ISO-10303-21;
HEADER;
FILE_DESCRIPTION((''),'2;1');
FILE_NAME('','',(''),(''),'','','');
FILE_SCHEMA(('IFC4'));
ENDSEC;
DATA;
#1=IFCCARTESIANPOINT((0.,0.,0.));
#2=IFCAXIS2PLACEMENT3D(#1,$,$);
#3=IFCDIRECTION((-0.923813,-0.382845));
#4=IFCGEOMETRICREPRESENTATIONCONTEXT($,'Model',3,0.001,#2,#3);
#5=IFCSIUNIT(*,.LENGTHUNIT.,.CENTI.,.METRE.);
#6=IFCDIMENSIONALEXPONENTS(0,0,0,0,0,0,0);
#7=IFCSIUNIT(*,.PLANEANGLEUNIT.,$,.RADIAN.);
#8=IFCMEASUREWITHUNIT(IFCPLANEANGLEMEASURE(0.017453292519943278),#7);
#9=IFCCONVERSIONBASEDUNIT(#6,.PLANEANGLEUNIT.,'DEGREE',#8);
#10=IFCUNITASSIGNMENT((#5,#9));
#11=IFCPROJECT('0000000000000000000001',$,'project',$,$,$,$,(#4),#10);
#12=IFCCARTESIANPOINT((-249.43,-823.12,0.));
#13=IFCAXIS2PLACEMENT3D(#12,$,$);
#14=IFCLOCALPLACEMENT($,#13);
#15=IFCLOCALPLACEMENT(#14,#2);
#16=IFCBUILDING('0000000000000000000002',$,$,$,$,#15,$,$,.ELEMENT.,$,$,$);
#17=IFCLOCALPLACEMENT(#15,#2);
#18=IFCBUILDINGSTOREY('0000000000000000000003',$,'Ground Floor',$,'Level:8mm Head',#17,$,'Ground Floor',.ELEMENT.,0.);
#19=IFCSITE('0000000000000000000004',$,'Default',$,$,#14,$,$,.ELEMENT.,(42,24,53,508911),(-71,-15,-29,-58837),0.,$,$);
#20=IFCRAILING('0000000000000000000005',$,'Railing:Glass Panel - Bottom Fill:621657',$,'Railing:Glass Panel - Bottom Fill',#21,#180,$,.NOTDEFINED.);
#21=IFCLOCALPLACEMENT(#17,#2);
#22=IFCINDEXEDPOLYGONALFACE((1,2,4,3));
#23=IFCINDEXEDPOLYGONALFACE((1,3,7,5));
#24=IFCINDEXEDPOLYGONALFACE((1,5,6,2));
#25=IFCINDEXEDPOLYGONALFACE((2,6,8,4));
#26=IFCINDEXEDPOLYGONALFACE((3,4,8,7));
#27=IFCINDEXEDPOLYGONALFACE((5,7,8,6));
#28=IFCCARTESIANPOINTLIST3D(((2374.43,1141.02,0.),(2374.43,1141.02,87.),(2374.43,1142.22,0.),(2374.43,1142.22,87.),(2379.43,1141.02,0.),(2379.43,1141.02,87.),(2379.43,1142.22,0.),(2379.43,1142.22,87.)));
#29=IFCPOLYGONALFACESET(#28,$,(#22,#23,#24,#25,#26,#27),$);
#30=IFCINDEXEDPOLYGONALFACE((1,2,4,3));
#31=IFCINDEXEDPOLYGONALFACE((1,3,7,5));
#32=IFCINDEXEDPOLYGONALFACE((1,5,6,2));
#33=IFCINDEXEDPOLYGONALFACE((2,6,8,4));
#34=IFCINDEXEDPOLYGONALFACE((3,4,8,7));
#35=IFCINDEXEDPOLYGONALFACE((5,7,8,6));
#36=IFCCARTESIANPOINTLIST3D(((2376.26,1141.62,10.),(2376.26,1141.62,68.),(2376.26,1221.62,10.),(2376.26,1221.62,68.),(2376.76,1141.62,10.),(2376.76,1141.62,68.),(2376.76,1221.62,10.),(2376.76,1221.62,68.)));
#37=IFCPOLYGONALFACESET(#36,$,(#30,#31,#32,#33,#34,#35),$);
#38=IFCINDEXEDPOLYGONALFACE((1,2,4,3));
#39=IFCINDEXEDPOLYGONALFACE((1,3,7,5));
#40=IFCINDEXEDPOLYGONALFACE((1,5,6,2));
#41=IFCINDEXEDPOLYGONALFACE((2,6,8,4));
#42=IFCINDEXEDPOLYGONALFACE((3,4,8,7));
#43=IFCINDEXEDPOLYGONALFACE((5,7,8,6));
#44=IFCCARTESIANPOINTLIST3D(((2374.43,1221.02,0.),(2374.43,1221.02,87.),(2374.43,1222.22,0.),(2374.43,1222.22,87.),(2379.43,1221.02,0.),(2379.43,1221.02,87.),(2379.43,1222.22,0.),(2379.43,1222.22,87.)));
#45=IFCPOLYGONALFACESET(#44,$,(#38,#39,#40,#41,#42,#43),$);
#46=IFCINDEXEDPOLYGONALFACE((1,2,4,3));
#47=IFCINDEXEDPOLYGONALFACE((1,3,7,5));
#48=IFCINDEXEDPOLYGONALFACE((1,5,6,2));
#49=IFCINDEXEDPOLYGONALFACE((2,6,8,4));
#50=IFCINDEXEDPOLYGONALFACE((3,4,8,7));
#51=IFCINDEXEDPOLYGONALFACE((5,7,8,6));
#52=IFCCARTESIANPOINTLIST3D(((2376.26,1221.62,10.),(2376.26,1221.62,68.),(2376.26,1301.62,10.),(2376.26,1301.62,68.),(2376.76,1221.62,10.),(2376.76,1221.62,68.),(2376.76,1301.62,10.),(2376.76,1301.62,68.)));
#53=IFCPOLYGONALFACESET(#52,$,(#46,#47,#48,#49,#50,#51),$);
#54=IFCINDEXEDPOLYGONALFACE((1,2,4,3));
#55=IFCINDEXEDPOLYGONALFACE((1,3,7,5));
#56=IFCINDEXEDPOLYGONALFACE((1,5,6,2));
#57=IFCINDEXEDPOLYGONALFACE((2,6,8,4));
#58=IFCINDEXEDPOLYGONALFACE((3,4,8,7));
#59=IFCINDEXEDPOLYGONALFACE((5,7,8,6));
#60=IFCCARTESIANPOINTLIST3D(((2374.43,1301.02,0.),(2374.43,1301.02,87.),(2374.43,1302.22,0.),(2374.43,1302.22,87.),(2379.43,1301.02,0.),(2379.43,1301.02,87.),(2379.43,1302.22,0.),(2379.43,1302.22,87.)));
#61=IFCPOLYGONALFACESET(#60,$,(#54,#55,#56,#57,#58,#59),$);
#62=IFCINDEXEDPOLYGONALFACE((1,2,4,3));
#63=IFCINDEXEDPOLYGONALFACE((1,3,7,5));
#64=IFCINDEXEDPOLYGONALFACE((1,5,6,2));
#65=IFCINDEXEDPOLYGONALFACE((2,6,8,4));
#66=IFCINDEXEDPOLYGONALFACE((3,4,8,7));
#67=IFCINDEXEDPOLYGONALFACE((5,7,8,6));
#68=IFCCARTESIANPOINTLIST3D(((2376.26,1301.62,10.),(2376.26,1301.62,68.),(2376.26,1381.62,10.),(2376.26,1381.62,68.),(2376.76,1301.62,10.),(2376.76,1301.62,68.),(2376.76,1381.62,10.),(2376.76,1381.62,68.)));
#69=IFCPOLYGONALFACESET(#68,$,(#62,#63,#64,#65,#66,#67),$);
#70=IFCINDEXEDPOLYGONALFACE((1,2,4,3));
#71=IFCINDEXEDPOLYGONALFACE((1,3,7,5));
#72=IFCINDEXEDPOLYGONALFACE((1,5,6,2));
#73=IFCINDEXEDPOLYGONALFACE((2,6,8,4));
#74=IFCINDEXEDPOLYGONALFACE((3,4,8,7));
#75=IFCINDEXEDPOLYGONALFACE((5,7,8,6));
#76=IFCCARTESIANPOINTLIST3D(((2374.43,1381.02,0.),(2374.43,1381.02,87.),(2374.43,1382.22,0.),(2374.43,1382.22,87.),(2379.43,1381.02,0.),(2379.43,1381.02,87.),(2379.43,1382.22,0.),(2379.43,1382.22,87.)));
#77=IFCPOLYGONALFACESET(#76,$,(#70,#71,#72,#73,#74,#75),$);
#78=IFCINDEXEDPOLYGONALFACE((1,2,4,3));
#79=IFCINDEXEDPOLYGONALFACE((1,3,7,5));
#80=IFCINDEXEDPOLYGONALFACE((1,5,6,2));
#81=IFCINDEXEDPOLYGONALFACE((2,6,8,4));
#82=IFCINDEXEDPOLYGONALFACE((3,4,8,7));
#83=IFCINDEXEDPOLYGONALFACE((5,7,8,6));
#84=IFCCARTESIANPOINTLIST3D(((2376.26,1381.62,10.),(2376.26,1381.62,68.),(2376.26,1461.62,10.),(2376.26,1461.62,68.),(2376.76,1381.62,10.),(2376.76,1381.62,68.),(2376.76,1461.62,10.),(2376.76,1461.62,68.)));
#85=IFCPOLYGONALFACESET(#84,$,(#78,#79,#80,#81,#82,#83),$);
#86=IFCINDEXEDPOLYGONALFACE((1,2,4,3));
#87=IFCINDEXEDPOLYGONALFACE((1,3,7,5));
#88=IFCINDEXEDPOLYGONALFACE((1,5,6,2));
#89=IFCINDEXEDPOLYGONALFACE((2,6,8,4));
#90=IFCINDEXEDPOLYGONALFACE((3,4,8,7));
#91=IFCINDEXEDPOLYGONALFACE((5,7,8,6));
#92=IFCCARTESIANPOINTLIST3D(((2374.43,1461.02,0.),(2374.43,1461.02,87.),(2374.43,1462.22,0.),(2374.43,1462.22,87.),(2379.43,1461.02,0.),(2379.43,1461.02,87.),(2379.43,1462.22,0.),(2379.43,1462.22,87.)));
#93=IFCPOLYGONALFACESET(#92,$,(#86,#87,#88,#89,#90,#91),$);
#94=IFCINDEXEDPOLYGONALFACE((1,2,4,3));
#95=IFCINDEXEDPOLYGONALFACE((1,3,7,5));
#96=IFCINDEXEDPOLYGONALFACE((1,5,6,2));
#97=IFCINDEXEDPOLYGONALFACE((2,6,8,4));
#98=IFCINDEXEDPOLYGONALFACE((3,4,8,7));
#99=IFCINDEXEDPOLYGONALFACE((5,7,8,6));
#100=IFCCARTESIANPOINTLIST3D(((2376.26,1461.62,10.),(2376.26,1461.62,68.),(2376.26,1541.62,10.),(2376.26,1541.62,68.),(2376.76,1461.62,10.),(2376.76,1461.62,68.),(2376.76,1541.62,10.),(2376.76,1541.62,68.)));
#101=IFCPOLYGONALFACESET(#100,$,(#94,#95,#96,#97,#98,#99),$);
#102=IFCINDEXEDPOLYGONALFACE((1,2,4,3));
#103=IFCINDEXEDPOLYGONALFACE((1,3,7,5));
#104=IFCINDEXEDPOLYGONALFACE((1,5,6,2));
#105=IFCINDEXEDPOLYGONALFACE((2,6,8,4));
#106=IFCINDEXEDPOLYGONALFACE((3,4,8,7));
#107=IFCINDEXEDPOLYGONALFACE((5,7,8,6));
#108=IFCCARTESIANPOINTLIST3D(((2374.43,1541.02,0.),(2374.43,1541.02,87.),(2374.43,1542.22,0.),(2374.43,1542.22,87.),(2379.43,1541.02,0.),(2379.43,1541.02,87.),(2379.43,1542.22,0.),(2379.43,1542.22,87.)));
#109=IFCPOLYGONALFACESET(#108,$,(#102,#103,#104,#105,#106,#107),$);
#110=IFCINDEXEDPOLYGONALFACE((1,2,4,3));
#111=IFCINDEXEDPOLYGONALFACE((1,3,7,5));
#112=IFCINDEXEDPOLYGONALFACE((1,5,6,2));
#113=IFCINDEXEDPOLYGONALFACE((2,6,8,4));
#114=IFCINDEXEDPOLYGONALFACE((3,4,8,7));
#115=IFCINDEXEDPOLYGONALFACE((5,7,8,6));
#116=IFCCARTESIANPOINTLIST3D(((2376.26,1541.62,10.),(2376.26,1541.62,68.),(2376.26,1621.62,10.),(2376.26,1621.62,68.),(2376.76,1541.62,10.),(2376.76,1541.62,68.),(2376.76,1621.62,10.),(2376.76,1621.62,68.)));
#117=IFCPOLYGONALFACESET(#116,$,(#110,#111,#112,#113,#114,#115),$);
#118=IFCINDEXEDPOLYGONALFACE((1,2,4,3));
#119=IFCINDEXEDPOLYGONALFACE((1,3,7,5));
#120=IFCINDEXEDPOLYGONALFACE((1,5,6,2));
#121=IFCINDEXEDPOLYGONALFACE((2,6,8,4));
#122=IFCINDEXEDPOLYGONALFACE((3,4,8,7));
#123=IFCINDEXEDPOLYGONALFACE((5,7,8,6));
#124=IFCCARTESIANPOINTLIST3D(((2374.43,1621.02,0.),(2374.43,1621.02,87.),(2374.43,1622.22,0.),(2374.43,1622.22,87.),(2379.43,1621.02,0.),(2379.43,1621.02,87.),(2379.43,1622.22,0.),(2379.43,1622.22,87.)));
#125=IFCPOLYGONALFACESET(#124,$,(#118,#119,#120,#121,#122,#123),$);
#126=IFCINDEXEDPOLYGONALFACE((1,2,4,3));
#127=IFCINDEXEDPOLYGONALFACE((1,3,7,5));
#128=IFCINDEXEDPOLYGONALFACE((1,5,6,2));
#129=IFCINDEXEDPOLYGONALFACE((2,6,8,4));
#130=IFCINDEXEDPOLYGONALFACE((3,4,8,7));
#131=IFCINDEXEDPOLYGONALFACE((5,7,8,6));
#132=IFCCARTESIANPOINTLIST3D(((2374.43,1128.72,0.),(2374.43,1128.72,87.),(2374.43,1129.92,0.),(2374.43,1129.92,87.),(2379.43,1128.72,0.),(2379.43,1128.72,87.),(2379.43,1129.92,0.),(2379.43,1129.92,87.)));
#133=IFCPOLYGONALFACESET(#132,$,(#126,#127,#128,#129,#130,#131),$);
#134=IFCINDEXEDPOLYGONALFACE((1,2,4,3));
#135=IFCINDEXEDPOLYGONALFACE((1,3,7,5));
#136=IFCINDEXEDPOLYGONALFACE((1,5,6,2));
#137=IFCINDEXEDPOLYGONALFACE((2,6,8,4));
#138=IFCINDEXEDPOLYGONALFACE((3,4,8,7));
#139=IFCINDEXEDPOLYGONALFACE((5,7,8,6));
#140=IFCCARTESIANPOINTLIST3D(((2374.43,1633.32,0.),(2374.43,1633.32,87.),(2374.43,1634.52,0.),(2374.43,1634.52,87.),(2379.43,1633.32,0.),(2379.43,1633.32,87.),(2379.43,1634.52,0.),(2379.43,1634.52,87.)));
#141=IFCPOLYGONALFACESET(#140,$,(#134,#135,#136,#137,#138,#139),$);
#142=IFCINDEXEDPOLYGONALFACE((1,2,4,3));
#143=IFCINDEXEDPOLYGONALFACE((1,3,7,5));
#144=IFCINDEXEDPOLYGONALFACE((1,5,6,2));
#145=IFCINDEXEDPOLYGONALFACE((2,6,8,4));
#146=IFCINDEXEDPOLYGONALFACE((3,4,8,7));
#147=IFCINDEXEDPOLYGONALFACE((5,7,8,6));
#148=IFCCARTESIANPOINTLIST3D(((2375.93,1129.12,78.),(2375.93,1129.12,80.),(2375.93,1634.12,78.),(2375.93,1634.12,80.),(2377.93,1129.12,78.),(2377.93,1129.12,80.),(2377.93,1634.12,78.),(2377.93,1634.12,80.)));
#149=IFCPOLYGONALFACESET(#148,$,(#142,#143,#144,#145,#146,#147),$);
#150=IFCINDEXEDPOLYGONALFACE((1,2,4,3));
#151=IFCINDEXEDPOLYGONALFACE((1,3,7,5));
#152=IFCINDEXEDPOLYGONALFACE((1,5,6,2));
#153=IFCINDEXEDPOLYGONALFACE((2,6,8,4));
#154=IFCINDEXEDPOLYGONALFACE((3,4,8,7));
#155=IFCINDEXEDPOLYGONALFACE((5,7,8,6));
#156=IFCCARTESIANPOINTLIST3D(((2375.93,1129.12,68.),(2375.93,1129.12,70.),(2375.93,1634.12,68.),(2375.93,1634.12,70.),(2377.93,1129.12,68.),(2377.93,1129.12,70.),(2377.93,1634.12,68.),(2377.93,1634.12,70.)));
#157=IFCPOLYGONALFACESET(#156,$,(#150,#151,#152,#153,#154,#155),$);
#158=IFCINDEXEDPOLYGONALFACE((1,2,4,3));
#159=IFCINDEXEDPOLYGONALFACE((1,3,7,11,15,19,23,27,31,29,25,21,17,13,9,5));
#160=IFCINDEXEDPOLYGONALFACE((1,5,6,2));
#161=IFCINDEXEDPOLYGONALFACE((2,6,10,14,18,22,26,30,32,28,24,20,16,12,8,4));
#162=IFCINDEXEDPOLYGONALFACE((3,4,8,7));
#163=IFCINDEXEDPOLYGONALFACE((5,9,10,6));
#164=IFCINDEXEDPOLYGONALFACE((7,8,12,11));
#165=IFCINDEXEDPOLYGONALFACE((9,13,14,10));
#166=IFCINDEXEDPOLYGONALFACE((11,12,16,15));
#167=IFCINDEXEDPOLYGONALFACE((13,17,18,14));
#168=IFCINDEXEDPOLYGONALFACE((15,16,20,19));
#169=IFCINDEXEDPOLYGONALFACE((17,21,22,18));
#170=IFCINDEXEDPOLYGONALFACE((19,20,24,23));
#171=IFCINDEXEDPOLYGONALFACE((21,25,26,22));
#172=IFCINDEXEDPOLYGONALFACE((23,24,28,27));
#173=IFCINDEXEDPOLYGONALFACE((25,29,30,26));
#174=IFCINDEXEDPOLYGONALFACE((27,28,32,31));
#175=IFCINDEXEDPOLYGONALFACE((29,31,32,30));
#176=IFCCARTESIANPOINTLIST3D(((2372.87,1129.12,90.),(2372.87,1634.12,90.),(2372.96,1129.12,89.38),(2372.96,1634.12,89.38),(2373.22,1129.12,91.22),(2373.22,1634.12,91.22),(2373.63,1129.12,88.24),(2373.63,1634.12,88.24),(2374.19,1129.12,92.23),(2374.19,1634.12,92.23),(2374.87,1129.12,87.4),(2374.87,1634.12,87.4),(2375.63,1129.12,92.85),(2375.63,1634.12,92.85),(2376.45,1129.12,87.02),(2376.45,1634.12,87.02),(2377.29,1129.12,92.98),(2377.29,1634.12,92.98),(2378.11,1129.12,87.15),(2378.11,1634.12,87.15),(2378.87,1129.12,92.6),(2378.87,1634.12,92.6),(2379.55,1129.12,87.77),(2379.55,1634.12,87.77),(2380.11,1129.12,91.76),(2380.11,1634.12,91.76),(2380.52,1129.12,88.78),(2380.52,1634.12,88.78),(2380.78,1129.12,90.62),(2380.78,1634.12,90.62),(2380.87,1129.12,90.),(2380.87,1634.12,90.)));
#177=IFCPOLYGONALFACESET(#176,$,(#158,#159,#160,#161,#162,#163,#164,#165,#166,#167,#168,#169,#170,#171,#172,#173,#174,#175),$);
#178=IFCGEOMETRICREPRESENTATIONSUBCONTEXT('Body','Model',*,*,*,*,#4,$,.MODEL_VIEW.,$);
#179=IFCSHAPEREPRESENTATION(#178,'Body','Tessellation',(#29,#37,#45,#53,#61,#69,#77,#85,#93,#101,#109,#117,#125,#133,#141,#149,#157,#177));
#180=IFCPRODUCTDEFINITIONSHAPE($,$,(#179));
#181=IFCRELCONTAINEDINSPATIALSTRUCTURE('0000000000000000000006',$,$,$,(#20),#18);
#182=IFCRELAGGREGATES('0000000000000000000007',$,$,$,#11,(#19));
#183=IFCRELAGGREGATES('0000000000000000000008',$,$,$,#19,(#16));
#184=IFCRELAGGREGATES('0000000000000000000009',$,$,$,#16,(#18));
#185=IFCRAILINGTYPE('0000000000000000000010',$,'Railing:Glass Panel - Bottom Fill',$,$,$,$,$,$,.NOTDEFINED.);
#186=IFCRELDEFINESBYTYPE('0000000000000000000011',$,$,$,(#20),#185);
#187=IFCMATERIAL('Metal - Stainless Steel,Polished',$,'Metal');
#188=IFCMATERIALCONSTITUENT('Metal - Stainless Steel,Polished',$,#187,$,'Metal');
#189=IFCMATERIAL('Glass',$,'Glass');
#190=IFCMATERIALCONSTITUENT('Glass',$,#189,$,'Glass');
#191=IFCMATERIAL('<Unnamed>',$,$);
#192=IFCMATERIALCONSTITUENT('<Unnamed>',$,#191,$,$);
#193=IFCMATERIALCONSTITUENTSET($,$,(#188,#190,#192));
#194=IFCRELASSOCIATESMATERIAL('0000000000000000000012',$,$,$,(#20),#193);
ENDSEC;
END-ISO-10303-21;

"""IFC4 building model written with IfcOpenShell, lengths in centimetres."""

from ifc_helpers import new_model, entity, si_unit, converted_unit, direction, frame, origin, place, context, subcontext, project, spatial, indexed_curve, outline, extrude, material, constituent, constituent_set, type_object, element, save


model = new_model("IFC4")

# Units and contexts
model_context = context("Model", 3, precision=0.001, world=origin(), true_north=direction((-0.923813, -0.382845)))
body_context = subcontext(model_context, "Body", "Model", "MODEL_VIEW")
ifc_project = project(units=[si_unit("LENGTHUNIT", "METRE", prefix="CENTI"), converted_unit("PLANEANGLEUNIT", "DEGREE", entity("IfcPlaneAngleMeasure", 0.017453292519943278), si_unit("PLANEANGLEUNIT", "RADIAN"), dimensions=[0, 0, 0, 0, 0, 0, 0])], contexts=[model_context])

# Site, building, storey
site_placement = place(None, frame((-249.43, -823.12, 0.0)))
site = spatial("IfcSite", under=ifc_project, at=site_placement, Name="Default", CompositionType="ELEMENT", RefLatitude=(42, 24, 53, 508911), RefLongitude=(-71, -15, -29, -58837), RefElevation=0.0)
building_placement = place(site_placement, origin())
building = spatial("IfcBuilding", under=site, at=building_placement, CompositionType="ELEMENT")
storey_placement = place(building_placement, origin())
storey = spatial("IfcBuildingStorey", under=building, at=storey_placement, Name="Ground Floor", ObjectType="Level:8mm Head", LongName="Ground Floor", CompositionType="ELEMENT", Elevation=0.0)

# Shared definitions
ifc_material_1 = material(Name="Glass", Category="Glass")

# Railing
ifc_material_2 = material(Name="Metal - Stainless Steel,Polished", Category="Metal")
ifc_constituent_1 = constituent(ifc_material_2, Name="Metal - Stainless Steel,Polished", Category="Metal")
ifc_constituent_2 = constituent(ifc_material_1, Name="Glass", Category="Glass")
ifc_material_3 = material(Name="<Unnamed>")
ifc_constituent_3 = constituent(ifc_material_3, Name="<Unnamed>")
ifc_constituent_set_1 = constituent_set(constituents=[ifc_constituent_1, ifc_constituent_2, ifc_constituent_3])
railing_type = type_object("IfcRailingType", Name="Railing:Glass Panel - Bottom Fill", PredefinedType="NOTDEFINED")
railing_1_placement = place(storey_placement, frame((2372.71, 1128.72, 0.0)))
element("IfcRailing", 1, at=railing_1_placement, inside=storey, type_object=railing_type, material=ifc_constituent_set_1, Name="Railing:Glass Panel - Bottom Fill:621657", ObjectType="Railing:Glass Panel - Bottom Fill", PredefinedType="NOTDEFINED", context=body_context, shape_type="SweptSolid", body=[
    extrude(outline(indexed_curve([(-2.5, -0.6), (2.5, -0.6), (2.5, 0.6), (-2.5, 0.6), (-2.5, -0.6)], self_intersect=False)), frame((4.22, 12.9, 0.0), z_axis=(0.0, 0.0, 1.0), x_axis=(-1.0, 0.0, 0.0)), (0.0, 0.0, 1.0), 87.0),
    extrude(outline(indexed_curve([(-0.25, -40.0), (0.25, -40.0), (0.25, 40.0), (-0.25, 40.0), (-0.25, -40.0)], self_intersect=False)), frame((3.8, 52.9, 10.0), z_axis=(0.0, 0.0, 1.0), x_axis=(-1.0, 0.0, 0.0)), (0.0, 0.0, 1.0), 58.0),
    extrude(outline(indexed_curve([(-2.5, -0.6), (2.5, -0.6), (2.5, 0.6), (-2.5, 0.6), (-2.5, -0.6)], self_intersect=False)), frame((4.22, 92.9, 0.0), z_axis=(0.0, 0.0, 1.0), x_axis=(-1.0, 0.0, 0.0)), (0.0, 0.0, 1.0), 87.0),
    extrude(outline(indexed_curve([(-0.25, -40.0), (0.25, -40.0), (0.25, 40.0), (-0.25, 40.0), (-0.25, -40.0)], self_intersect=False)), frame((3.8, 132.9, 10.0), z_axis=(0.0, 0.0, 1.0), x_axis=(-1.0, 0.0, 0.0)), (0.0, 0.0, 1.0), 58.0),
    extrude(outline(indexed_curve([(-2.5, -0.6), (2.5, -0.6), (2.5, 0.6), (-2.5, 0.6), (-2.5, -0.6)], self_intersect=False)), frame((4.22, 172.9, 0.0), z_axis=(0.0, 0.0, 1.0), x_axis=(-1.0, 0.0, 0.0)), (0.0, 0.0, 1.0), 87.0),
    extrude(outline(indexed_curve([(-0.25, -40.0), (0.25, -40.0), (0.25, 40.0), (-0.25, 40.0), (-0.25, -40.0)], self_intersect=False)), frame((3.8, 212.9, 10.0), z_axis=(0.0, 0.0, 1.0), x_axis=(-1.0, 0.0, 0.0)), (0.0, 0.0, 1.0), 58.0),
    extrude(outline(indexed_curve([(-2.5, -0.6), (2.5, -0.6), (2.5, 0.6), (-2.5, 0.6), (-2.5, -0.6)], self_intersect=False)), frame((4.22, 252.9, 0.0), z_axis=(0.0, 0.0, 1.0), x_axis=(-1.0, 0.0, 0.0)), (0.0, 0.0, 1.0), 87.0),
    extrude(outline(indexed_curve([(-0.25, -40.0), (0.25, -40.0), (0.25, 40.0), (-0.25, 40.0), (-0.25, -40.0)], self_intersect=False)), frame((3.8, 292.9, 10.0), z_axis=(0.0, 0.0, 1.0), x_axis=(-1.0, 0.0, 0.0)), (0.0, 0.0, 1.0), 58.0),
    extrude(outline(indexed_curve([(-2.5, -0.6), (2.5, -0.6), (2.5, 0.6), (-2.5, 0.6), (-2.5, -0.6)], self_intersect=False)), frame((4.22, 332.9, 0.0), z_axis=(0.0, 0.0, 1.0), x_axis=(-1.0, 0.0, 0.0)), (0.0, 0.0, 1.0), 87.0),
    extrude(outline(indexed_curve([(-0.25, -40.0), (0.25, -40.0), (0.25, 40.0), (-0.25, 40.0), (-0.25, -40.0)], self_intersect=False)), frame((3.8, 372.9, 10.0), z_axis=(0.0, 0.0, 1.0), x_axis=(-1.0, 0.0, 0.0)), (0.0, 0.0, 1.0), 58.0),
    extrude(outline(indexed_curve([(-2.5, -0.6), (2.5, -0.6), (2.5, 0.6), (-2.5, 0.6), (-2.5, -0.6)], self_intersect=False)), frame((4.22, 412.9, 0.0), z_axis=(0.0, 0.0, 1.0), x_axis=(-1.0, 0.0, 0.0)), (0.0, 0.0, 1.0), 87.0),
    extrude(outline(indexed_curve([(-0.25, -40.0), (0.25, -40.0), (0.25, 40.0), (-0.25, 40.0), (-0.25, -40.0)], self_intersect=False)), frame((3.8, 452.9, 10.0), z_axis=(0.0, 0.0, 1.0), x_axis=(-1.0, 0.0, 0.0)), (0.0, 0.0, 1.0), 58.0),
    extrude(outline(indexed_curve([(-2.5, -0.6), (2.5, -0.6), (2.5, 0.6), (-2.5, 0.6), (-2.5, -0.6)], self_intersect=False)), frame((4.22, 492.9, 0.0), z_axis=(0.0, 0.0, 1.0), x_axis=(-1.0, 0.0, 0.0)), (0.0, 0.0, 1.0), 87.0),
    extrude(outline(indexed_curve([(-2.5, -0.6), (2.5, -0.6), (2.5, 0.6), (-2.5, 0.6), (-2.5, -0.6)], self_intersect=False)), frame((4.22, 0.6, 0.0), z_axis=(0.0, 0.0, 1.0), x_axis=(-1.0, 0.0, 0.0)), (0.0, 0.0, 1.0), 87.0),
    extrude(outline(indexed_curve([(-2.5, -0.6), (2.5, -0.6), (2.5, 0.6), (-2.5, 0.6), (-2.5, -0.6)], self_intersect=False)), frame((4.22, 505.2, 0.0), z_axis=(0.0, 0.0, 1.0), x_axis=(-1.0, 0.0, 0.0)), (0.0, 0.0, 1.0), 87.0),
    extrude(outline(indexed_curve([(-252.5, -1.0), (252.5, -1.0), (252.5, 1.0), (-252.5, 1.0), (-252.5, -1.0)], self_intersect=False)), frame((4.22, 252.9, 78.0), z_axis=(0.0, 0.0, 1.0), x_axis=(0.0, -1.0, 0.0)), (0.0, 0.0, 1.0), 2.0),
    extrude(outline(indexed_curve([(-252.5, -1.0), (252.5, -1.0), (252.5, 1.0), (-252.5, 1.0), (-252.5, -1.0)], self_intersect=False)), frame((4.22, 252.9, 68.0), z_axis=(0.0, 0.0, 1.0), x_axis=(0.0, -1.0, 0.0)), (0.0, 0.0, 1.0), 2.0),
    extrude(outline(indexed_curve([(-1.09, -3.85), (0.18, -3.85), (1.42, -3.18), (2.41, -1.97), (2.98, -0.41), (3.04, 1.22), (2.58, 2.63), (1.67, 3.59), (1.09, 3.85), (-0.18, 3.85), (-1.42, 3.18), (-2.41, 1.97), (-2.98, 0.41), (-3.04, -1.22), (-2.58, -2.63), (-1.67, -3.59), (-1.09, -3.85)], self_intersect=False)), frame((4.16, 0.4, 90.0), z_axis=(0.0, 1.0, 0.0), x_axis=(-0.27267, 0.0, -0.962108)), (0.0, 0.0, 1.0), 505.0),
])

save(model, "model.ifc")
